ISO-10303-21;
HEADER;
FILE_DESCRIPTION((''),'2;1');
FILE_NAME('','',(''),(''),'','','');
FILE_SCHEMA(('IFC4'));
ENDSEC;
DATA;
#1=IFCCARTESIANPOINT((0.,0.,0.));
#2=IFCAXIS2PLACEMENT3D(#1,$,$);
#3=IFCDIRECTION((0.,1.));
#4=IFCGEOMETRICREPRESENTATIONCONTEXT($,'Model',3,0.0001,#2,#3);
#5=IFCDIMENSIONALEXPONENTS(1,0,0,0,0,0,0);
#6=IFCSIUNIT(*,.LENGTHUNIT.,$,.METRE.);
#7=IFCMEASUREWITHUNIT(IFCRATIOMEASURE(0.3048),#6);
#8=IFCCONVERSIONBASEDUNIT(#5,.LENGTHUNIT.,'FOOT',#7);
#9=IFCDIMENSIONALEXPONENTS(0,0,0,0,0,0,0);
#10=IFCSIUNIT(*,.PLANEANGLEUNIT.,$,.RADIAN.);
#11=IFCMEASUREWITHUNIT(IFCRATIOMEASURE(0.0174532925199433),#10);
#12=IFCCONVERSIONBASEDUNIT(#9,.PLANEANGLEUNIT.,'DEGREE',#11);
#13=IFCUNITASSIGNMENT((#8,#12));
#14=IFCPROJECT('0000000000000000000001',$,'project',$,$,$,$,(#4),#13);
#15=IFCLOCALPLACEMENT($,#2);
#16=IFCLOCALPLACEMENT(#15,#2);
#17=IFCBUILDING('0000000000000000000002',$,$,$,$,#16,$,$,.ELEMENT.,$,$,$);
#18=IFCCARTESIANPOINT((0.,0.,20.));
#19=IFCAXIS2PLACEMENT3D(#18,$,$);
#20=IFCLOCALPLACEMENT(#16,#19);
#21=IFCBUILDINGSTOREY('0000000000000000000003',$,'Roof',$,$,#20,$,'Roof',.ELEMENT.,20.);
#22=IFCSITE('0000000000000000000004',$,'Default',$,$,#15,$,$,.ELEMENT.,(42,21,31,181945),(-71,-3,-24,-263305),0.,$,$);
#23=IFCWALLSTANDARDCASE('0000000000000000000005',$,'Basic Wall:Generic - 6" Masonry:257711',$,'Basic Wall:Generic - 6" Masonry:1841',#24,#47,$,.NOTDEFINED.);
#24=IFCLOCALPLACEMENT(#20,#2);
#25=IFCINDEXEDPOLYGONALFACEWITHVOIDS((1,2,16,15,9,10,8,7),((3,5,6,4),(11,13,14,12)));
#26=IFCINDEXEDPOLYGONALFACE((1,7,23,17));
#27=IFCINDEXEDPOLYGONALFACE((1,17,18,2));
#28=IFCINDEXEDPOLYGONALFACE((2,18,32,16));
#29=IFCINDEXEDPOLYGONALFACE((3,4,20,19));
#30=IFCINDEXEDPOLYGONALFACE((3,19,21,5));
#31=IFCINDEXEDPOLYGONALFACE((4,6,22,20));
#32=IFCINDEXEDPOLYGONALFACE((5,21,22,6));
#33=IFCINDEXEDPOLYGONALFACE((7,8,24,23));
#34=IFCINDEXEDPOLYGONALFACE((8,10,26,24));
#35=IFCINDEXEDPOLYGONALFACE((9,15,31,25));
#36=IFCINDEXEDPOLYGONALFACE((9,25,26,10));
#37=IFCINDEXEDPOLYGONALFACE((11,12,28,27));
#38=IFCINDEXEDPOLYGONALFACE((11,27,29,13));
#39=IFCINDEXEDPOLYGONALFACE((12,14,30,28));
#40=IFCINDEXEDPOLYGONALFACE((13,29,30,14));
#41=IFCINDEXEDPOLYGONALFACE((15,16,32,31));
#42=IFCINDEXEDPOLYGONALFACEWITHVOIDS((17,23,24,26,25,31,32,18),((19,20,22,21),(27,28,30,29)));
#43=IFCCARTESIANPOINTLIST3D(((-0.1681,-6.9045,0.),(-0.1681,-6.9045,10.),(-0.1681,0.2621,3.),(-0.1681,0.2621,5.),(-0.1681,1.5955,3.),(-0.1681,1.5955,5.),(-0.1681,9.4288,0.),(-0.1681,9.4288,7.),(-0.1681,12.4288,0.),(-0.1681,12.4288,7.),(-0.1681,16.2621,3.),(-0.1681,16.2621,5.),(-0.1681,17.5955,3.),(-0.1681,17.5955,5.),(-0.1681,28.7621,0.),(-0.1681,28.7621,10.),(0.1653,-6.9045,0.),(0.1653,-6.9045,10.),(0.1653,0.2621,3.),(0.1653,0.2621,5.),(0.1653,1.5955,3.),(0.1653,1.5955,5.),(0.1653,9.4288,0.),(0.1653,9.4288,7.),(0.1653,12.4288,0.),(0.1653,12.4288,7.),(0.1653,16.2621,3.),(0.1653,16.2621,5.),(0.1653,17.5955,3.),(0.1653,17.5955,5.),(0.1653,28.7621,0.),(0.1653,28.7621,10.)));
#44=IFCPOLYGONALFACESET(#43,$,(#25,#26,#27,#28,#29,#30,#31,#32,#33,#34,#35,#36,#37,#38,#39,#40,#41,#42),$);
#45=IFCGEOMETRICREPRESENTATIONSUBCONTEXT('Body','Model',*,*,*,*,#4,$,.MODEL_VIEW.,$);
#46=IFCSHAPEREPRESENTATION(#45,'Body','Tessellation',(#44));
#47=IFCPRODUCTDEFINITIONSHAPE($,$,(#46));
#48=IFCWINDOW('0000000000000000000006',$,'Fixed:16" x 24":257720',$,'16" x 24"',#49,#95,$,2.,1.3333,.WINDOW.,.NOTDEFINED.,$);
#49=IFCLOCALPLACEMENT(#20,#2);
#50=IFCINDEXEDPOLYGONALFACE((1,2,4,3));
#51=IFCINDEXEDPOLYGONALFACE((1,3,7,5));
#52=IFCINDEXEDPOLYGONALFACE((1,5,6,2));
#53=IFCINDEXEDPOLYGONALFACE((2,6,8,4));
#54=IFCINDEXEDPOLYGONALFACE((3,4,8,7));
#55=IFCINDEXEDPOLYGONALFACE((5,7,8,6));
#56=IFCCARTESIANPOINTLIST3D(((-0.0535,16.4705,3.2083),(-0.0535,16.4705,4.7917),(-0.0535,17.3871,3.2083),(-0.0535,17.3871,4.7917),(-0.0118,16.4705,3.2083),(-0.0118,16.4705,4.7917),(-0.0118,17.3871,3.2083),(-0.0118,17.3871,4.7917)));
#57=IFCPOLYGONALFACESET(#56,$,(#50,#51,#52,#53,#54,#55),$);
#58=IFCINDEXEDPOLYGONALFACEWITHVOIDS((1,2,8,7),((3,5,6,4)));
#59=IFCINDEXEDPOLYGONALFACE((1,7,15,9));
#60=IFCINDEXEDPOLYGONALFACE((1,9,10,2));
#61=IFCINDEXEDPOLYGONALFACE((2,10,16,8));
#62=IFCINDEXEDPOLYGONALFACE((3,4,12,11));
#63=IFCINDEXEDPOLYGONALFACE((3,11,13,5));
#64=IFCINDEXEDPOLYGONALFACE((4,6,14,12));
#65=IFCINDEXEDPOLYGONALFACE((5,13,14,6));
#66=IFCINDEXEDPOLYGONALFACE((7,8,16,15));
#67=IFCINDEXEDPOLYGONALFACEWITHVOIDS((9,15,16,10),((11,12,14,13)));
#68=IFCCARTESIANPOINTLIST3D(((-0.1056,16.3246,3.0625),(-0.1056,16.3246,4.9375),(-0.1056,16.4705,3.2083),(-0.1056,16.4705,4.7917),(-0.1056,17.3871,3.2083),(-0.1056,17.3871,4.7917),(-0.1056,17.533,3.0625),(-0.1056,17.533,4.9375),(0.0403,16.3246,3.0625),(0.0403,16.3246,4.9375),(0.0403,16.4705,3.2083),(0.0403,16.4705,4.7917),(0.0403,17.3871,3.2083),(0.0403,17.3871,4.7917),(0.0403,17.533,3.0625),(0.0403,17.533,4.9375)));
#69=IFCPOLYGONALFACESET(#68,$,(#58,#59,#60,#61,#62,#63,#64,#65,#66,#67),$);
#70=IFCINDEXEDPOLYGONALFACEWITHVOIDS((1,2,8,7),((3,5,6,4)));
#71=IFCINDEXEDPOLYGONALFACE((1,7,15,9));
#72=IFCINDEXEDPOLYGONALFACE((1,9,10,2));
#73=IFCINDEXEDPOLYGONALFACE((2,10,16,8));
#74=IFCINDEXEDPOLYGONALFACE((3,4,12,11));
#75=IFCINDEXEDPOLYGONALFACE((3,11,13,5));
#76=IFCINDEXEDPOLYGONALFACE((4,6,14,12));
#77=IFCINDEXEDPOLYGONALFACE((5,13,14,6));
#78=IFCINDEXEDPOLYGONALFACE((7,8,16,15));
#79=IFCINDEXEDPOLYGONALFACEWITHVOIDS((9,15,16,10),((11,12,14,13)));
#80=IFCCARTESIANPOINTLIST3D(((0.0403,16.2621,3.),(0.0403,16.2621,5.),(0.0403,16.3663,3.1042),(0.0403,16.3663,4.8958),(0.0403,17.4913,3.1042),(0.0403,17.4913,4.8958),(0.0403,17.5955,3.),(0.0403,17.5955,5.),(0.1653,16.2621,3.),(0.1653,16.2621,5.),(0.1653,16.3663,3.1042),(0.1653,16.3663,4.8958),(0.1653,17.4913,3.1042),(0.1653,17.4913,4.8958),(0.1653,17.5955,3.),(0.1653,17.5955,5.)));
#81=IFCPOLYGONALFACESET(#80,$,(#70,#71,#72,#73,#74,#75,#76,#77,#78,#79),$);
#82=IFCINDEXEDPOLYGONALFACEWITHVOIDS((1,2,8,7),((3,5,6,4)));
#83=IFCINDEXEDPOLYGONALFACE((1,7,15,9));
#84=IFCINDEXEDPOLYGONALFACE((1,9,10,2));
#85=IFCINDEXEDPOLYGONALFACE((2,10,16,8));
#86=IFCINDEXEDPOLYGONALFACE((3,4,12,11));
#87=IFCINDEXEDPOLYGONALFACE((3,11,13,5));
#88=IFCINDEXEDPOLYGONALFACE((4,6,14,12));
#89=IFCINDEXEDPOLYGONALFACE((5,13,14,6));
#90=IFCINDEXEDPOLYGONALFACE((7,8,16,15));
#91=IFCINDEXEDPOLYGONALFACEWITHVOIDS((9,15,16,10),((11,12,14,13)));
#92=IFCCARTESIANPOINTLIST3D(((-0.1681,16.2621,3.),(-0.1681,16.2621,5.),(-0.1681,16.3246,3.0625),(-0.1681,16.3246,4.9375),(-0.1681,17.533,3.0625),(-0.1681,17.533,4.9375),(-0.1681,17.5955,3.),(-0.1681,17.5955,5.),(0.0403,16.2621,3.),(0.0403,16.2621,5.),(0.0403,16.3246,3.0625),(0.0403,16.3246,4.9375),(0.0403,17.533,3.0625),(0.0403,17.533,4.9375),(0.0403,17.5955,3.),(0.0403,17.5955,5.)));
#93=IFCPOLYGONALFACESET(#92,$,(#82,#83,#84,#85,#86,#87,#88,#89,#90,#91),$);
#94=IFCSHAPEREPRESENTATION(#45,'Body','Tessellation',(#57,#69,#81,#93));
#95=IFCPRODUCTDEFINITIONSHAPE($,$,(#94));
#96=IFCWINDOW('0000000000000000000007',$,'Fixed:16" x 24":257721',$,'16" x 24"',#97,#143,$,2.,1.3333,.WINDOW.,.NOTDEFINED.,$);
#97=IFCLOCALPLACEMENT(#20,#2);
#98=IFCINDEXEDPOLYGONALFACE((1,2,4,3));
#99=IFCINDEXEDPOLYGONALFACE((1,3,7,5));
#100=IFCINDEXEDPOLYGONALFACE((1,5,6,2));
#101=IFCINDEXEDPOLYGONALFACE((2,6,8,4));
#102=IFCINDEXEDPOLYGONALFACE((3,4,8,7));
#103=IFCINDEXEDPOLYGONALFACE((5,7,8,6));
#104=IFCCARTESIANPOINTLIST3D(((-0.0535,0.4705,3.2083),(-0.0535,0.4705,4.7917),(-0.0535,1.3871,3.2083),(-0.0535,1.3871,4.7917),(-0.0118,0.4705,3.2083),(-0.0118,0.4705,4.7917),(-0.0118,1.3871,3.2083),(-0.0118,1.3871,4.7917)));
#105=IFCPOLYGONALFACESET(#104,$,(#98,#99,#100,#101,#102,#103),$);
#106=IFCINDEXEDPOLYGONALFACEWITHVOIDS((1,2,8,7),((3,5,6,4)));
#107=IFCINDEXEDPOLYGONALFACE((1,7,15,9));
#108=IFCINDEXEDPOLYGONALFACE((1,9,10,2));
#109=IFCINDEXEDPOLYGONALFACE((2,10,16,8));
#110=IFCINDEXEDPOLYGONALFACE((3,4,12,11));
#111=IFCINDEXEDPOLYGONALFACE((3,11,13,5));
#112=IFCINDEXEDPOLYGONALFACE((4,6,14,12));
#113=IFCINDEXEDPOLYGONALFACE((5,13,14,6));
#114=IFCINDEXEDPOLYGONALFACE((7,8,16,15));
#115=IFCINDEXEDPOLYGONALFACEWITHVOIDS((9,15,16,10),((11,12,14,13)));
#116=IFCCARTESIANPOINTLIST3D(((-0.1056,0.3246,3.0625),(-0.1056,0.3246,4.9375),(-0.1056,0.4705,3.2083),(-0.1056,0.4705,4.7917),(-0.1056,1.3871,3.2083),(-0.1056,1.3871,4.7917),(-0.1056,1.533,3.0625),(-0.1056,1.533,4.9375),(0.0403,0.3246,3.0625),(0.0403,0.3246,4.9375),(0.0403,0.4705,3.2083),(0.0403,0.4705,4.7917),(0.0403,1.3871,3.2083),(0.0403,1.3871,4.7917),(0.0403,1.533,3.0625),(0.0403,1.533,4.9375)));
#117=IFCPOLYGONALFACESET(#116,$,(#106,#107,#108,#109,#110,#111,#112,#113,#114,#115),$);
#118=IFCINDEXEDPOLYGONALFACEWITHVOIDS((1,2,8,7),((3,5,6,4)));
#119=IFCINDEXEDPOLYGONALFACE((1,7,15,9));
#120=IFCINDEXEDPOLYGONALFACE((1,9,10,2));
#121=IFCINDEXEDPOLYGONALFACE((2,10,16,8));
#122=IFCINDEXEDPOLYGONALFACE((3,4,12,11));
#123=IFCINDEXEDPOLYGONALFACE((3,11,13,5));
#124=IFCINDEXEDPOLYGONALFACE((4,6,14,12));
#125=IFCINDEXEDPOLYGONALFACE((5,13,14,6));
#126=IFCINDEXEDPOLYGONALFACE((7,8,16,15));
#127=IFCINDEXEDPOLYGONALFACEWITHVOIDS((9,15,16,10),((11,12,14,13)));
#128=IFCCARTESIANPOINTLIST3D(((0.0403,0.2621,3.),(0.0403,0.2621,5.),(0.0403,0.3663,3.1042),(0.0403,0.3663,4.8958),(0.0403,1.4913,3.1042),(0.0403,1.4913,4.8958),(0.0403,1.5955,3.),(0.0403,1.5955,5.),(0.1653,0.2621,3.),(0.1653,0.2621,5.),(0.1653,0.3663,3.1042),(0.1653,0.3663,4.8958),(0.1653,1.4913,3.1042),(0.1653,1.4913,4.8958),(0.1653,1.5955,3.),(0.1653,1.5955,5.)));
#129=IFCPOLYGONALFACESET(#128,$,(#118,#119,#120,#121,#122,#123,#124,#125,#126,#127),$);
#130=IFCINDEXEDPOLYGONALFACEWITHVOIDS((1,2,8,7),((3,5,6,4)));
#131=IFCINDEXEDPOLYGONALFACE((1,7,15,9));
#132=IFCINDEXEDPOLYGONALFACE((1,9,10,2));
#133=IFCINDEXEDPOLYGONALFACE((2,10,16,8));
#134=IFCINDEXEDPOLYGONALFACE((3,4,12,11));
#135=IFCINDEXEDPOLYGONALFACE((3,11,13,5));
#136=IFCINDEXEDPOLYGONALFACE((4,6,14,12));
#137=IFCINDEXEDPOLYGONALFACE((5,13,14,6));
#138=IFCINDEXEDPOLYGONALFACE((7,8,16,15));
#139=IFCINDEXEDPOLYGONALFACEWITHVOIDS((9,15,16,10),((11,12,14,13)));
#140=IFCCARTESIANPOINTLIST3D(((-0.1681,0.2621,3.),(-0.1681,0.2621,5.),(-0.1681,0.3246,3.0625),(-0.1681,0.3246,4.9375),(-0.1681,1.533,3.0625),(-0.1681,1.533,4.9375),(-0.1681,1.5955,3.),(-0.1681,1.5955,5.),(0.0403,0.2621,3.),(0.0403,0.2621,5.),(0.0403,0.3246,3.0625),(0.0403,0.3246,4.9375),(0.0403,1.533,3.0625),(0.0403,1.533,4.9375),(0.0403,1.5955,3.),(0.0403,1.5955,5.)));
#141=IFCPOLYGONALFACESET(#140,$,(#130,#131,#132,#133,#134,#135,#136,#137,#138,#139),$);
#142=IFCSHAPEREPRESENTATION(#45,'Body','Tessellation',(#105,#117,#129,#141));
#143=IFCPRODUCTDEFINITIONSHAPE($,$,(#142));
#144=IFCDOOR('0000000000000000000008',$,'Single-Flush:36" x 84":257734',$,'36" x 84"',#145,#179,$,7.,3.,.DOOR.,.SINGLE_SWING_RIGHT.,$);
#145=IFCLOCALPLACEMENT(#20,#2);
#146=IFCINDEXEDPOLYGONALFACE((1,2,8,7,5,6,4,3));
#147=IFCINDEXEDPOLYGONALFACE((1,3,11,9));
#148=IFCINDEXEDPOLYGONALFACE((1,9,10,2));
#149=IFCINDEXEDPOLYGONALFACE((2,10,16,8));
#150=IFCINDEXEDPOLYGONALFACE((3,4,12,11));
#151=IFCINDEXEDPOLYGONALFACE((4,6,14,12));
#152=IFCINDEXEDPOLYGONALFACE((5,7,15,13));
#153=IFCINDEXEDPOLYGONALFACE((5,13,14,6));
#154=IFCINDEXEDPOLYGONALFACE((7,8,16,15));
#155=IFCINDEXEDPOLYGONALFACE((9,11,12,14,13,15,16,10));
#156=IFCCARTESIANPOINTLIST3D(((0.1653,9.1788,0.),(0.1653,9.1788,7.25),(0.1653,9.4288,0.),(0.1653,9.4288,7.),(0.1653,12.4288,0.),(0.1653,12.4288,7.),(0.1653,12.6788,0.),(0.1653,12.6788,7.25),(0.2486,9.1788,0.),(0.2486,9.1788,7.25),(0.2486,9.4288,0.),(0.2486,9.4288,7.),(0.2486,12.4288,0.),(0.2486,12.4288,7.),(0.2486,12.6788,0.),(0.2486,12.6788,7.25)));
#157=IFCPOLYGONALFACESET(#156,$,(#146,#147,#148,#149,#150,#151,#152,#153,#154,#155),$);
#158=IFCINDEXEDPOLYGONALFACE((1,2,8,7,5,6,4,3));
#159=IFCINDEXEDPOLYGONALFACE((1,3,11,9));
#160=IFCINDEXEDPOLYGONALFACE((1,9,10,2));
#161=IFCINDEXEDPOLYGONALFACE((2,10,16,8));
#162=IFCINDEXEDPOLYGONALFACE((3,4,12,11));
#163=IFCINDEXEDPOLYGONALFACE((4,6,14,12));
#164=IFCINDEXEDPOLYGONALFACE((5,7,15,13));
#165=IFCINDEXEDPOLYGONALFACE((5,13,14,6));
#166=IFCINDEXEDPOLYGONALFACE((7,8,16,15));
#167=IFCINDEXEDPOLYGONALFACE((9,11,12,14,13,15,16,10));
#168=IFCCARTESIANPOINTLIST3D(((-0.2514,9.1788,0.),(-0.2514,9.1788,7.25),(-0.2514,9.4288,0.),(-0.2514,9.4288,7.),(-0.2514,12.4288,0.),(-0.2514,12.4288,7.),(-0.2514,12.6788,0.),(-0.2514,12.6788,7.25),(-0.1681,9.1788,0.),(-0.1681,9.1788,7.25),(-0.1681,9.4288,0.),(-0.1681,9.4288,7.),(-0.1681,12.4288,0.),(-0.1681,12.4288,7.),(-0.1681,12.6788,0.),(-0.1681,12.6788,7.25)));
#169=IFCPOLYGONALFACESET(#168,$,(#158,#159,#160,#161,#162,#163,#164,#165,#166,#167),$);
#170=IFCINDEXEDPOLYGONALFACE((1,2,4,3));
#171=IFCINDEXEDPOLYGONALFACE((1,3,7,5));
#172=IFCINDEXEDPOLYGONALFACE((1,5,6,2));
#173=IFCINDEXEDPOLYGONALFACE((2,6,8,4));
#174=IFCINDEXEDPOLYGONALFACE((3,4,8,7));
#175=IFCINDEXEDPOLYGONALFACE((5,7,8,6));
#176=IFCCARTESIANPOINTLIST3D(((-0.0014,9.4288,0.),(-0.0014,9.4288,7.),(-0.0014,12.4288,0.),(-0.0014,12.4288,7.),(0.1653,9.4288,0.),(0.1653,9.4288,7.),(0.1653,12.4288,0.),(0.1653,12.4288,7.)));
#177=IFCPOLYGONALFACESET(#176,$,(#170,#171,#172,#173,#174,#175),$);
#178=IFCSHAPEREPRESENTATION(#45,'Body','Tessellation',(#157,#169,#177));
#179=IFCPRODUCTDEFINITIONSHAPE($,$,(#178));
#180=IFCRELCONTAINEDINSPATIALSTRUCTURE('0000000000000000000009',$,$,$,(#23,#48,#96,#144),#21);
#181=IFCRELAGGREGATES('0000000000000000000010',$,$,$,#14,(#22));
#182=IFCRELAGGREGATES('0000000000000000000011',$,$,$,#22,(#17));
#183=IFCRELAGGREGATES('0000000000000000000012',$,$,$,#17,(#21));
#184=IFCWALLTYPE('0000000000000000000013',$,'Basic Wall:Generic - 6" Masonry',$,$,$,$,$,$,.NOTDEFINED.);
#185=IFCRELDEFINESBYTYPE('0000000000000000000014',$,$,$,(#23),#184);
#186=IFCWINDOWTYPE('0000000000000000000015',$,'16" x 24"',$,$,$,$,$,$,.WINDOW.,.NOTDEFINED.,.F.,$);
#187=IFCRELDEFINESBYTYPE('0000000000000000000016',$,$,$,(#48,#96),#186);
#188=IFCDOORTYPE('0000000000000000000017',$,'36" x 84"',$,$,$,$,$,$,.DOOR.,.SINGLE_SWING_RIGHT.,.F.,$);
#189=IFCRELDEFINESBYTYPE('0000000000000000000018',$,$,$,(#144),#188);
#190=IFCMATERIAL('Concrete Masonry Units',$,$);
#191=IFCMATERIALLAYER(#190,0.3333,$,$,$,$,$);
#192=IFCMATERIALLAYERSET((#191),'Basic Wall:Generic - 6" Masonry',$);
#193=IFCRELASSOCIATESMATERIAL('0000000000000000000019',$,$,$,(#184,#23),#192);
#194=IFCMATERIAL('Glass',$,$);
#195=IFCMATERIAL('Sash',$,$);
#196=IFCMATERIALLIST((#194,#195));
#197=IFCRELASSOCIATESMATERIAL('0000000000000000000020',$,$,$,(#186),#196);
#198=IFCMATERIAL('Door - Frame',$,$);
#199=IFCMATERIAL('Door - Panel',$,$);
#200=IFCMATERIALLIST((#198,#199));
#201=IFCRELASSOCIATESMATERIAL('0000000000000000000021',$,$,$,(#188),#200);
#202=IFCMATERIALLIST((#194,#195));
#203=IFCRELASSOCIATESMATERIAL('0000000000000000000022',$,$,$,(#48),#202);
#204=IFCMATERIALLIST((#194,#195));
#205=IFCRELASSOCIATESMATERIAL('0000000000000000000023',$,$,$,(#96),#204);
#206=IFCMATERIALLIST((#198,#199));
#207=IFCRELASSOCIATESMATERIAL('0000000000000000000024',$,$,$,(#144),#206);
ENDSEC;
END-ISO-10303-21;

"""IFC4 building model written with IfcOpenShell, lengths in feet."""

from ifc_helpers import new_model, entity, si_unit, converted_unit, direction, frame, frame_2d, origin, origin_2d_with_axis, place, context, subcontext, project, spatial, polyline, rectangle, outline, extrude, source, transform, mapped, material, material_list, layer, layer_set, layer_usage, type_object, type_shapes, element, fill, save


model = new_model("IFC4")

# Units and contexts
model_context = context("Model", 3, precision=0.0001, world=origin(), true_north=direction((0.0, 1.0)))
body_context = subcontext(model_context, "Body", "Model", "MODEL_VIEW")
ifc_project = project(units=[converted_unit("LENGTHUNIT", "FOOT", entity("IfcRatioMeasure", 0.3048), si_unit("LENGTHUNIT", "METRE"), dimensions=[1, 0, 0, 0, 0, 0, 0]), converted_unit("PLANEANGLEUNIT", "DEGREE", entity("IfcRatioMeasure", 0.0174532925199433), si_unit("PLANEANGLEUNIT", "RADIAN"), dimensions=[0, 0, 0, 0, 0, 0, 0])], contexts=[model_context])

# Site, building, storey
site_placement = place(None, origin())
site = spatial("IfcSite", under=ifc_project, at=site_placement, Name="Default", CompositionType="ELEMENT", RefLatitude=(42, 21, 31, 181945), RefLongitude=(-71, -3, -24, -263305), RefElevation=0.0)
building_placement = place(site_placement, origin())
building = spatial("IfcBuilding", under=site, at=building_placement, CompositionType="ELEMENT")
storey_placement = place(building_placement, frame((0.0, 0.0, 20.0)))
storey = spatial("IfcBuildingStorey", under=building, at=storey_placement, Name="Roof", LongName="Roof", CompositionType="ELEMENT", Elevation=20.0)

# Shared definitions
ifc_material_1 = material(Name="Concrete Masonry Units")
ifc_layer = layer(ifc_material_1, 0.3333)
ifc_layer_set = layer_set([ifc_layer], Name="Basic Wall:Generic - 6\" Masonry")
wall_type = type_object("IfcWallType", Name="Basic Wall:Generic - 6\" Masonry", PredefinedType="NOTDEFINED", material=ifc_layer_set)
ifc_material_2 = material(Name="Glass")
ifc_material_3 = material(Name="Sash")
ifc_material_list_1 = material_list([ifc_material_2, ifc_material_3])
window_type = type_object("IfcWindowType", Name="16\" x 24\"", ParameterTakesPrecedence=False, PartitioningType="NOTDEFINED", PredefinedType="WINDOW", material=ifc_material_list_1)
shared_shape_1 = source(origin(), body_context, "Body", "SweptSolid", [
    extrude(rectangle(XDim=0.0417, YDim=0.9167, at=origin_2d_with_axis()), frame((0.6667, 0.1979, 0.2083), z_axis=(0.0, 0.0, 1.0), x_axis=(0.0, 1.0, 0.0)), (0.0, 0.0, 1.0), 1.5833),
    extrude(outline(polyline([(-0.6042, -0.9375), (0.6042, -0.9375), (0.6042, 0.9375), (-0.6042, 0.9375), (-0.6042, -0.9375)]), holes=[polyline([(-0.4583, -0.7917), (-0.4583, 0.7917), (0.4583, 0.7917), (0.4583, -0.7917), (-0.4583, -0.7917)])]), frame((0.6667, 0.125, 1.0), z_axis=(0.0, 1.0, 0.0), x_axis=(1.0, 0.0, 0.0)), (0.0, 0.0, 1.0), 0.1458),
    extrude(outline(polyline([(-0.6667, -1.0), (0.6667, -1.0), (0.6667, 1.0), (-0.6667, 1.0), (-0.6667, -1.0)]), holes=[polyline([(-0.5625, -0.8958), (-0.5625, 0.8958), (0.5625, 0.8958), (0.5625, -0.8958), (-0.5625, -0.8958)])]), frame((0.6667, 0.0, 1.0), z_axis=(0.0, 1.0, 0.0), x_axis=(1.0, 0.0, 0.0)), (0.0, 0.0, 1.0), 0.125),
    extrude(outline(polyline([(-1.0, -0.6667), (1.0, -0.6667), (1.0, 0.6667), (-1.0, 0.6667), (-1.0, -0.6667)]), holes=[polyline([(-0.9375, -0.6042), (-0.9375, 0.6042), (0.9375, 0.6042), (0.9375, -0.6042), (-0.9375, -0.6042)])]), frame((0.6667, 0.125, 1.0), z_axis=(0.0, 1.0, 0.0), x_axis=(0.0, 0.0, -1.0)), (0.0, 0.0, 1.0), 0.2083),
])
type_shapes(window_type, [shared_shape_1])
ifc_material_4 = material(Name="Door - Frame")
ifc_material_5 = material(Name="Door - Panel")
ifc_material_list_2 = material_list([ifc_material_4, ifc_material_5])
door_type = type_object("IfcDoorType", Name="36\" x 84\"", OperationType="SINGLE_SWING_RIGHT", ParameterTakesPrecedence=False, PredefinedType="DOOR", material=ifc_material_list_2)
shared_shape_2 = source(origin(), body_context, "Body", "SweptSolid", [
    extrude(outline(polyline([(-1.75, -3.6875), (1.75, -3.6875), (1.75, 3.5625), (1.5, 3.5625), (1.5, -3.4375), (-1.5, -3.4375), (-1.5, 3.5625), (-1.75, 3.5625), (-1.75, -3.6875)])), frame((1.5, 0.3333, 3.5625), z_axis=(0.0, 1.0, 0.0), x_axis=(1.0, 0.0, 0.0)), (0.0, 0.0, 1.0), 0.0833),
    extrude(outline(polyline([(-3.6875, -1.75), (3.5625, -1.75), (3.5625, -1.5), (-3.4375, -1.5), (-3.4375, 1.5), (3.5625, 1.5), (3.5625, 1.75), (-3.6875, 1.75), (-3.6875, -1.75)])), frame((1.5, -0.0833, 3.5625), z_axis=(0.0, 1.0, 0.0), x_axis=(0.0, 0.0, -1.0)), (0.0, 0.0, 1.0), 0.0833),
    extrude(rectangle(XDim=0.1667, YDim=3.0, at=frame_2d((0.0, 0.0), x_axis=(1.0, 0.0))), frame((1.5, 0.25, 0.0), z_axis=(0.0, 0.0, 1.0), x_axis=(0.0, 1.0, 0.0)), (0.0, 0.0, 1.0), 7.0),
])
type_shapes(door_type, [shared_shape_2])

# Wall, openings, windows, door
ifc_layer_usage_1 = layer_usage(ifc_layer_set, "AXIS2", "NEGATIVE", 0.1667)
wall_1_placement = place(storey_placement, frame((-0.0014, -6.9045, 0.0), z_axis=(0.0, 0.0, 1.0), x_axis=(0.0, 1.0, 0.0)))
wall_1 = element("IfcWallStandardCase", 1, at=wall_1_placement, inside=storey, type_object=wall_type, material=ifc_layer_usage_1, Name="Basic Wall:Generic - 6\" Masonry:257711", ObjectType="Basic Wall:Generic - 6\" Masonry:1841", PredefinedType="NOTDEFINED", context=body_context, shape_type="SweptSolid", body=[
    extrude(rectangle(XDim=35.6667, YDim=0.3333, at=frame_2d((17.8333, 0.0), x_axis=(-1.0, 0.0))), origin(), (0.0, 0.0, 1.0), 10.0),
])
opening_1_placement = place(wall_1_placement, frame((19.3333, 0.1667, 0.0)))
opening_1 = element("IfcOpeningElement", 2, at=opening_1_placement, cuts=wall_1, ObjectType="Opening", PredefinedType="OPENING", context=body_context, shape_type="SweptSolid", body=[
    extrude(rectangle(XDim=3.0, YDim=7.0, at=frame_2d((3.5, 1.5), x_axis=(0.0, 1.0))), frame((0.0, 0.0, 0.0), z_axis=(0.0, -1.0, 0.0), x_axis=(0.0, 0.0, 1.0)), (0.0, 0.0, 1.0), 0.3333),
])
opening_2_placement = place(wall_1_placement, frame((23.1667, -0.1667, 3.0)))
opening_2 = element("IfcOpeningElement", 3, at=opening_2_placement, cuts=wall_1, ObjectType="Opening", PredefinedType="OPENING", context=body_context, shape_type="SweptSolid", body=[
    extrude(rectangle(XDim=2.0, YDim=1.3333, at=frame_2d((1.0, 0.6667), x_axis=(-1.0, 0.0))), frame((0.0, 0.0, 0.0), z_axis=(0.0, 1.0, 0.0), x_axis=(0.0, 0.0, 1.0)), (0.0, 0.0, 1.0), 0.3333),
])
opening_3_placement = place(wall_1_placement, frame((7.1667, -0.1667, 3.0)))
opening_3 = element("IfcOpeningElement", 4, at=opening_3_placement, cuts=wall_1, ObjectType="Opening", PredefinedType="OPENING", context=body_context, shape_type="SweptSolid", body=[
    extrude(rectangle(XDim=2.0, YDim=1.3333, at=frame_2d((1.0, 0.6667), x_axis=(-1.0, 0.0))), frame((0.0, 0.0, 0.0), z_axis=(0.0, 1.0, 0.0), x_axis=(0.0, 0.0, 1.0)), (0.0, 0.0, 1.0), 0.3333),
])
ifc_material_list_3 = material_list([ifc_material_2, ifc_material_3])
window_1_placement = place(opening_2_placement, origin())
window_1 = element("IfcWindow", 5, at=window_1_placement, inside=storey, type_object=window_type, material=ifc_material_list_3, Name="Fixed:16\" x 24\":257720", ObjectType="16\" x 24\"", OverallHeight=2.0, OverallWidth=1.3333, PartitioningType="NOTDEFINED", PredefinedType="WINDOW", context=body_context, shape_type="MappedRepresentation", body=[
    mapped(shared_shape_1, transform((0.0, 0.0, 0.0), scale=1.0)),
])
fill(opening_2, window_1)
ifc_material_list_4 = material_list([ifc_material_2, ifc_material_3])
window_2_placement = place(opening_3_placement, origin())
window_2 = element("IfcWindow", 6, at=window_2_placement, inside=storey, type_object=window_type, material=ifc_material_list_4, Name="Fixed:16\" x 24\":257721", ObjectType="16\" x 24\"", OverallHeight=2.0, OverallWidth=1.3333, PartitioningType="NOTDEFINED", PredefinedType="WINDOW", context=body_context, shape_type="MappedRepresentation", body=[
    mapped(shared_shape_1, transform((0.0, 0.0, 0.0), scale=1.0)),
])
fill(opening_3, window_2)
ifc_material_list_5 = material_list([ifc_material_4, ifc_material_5])
door_1_placement = place(opening_1_placement, frame((0.0, 0.0, 0.0), z_axis=(0.0, 0.0, 1.0), x_axis=(-1.0, 0.0, 0.0)))
door_1 = element("IfcDoor", 7, at=door_1_placement, inside=storey, type_object=door_type, material=ifc_material_list_5, Name="Single-Flush:36\" x 84\":257734", ObjectType="36\" x 84\"", OperationType="SINGLE_SWING_RIGHT", OverallHeight=7.0, OverallWidth=3.0, PredefinedType="DOOR", context=body_context, shape_type="MappedRepresentation", body=[
    mapped(shared_shape_2, transform((0.0, 0.0, 0.0), scale=1.0)),
])
fill(opening_1, door_1)

save(model, "model.ifc")
